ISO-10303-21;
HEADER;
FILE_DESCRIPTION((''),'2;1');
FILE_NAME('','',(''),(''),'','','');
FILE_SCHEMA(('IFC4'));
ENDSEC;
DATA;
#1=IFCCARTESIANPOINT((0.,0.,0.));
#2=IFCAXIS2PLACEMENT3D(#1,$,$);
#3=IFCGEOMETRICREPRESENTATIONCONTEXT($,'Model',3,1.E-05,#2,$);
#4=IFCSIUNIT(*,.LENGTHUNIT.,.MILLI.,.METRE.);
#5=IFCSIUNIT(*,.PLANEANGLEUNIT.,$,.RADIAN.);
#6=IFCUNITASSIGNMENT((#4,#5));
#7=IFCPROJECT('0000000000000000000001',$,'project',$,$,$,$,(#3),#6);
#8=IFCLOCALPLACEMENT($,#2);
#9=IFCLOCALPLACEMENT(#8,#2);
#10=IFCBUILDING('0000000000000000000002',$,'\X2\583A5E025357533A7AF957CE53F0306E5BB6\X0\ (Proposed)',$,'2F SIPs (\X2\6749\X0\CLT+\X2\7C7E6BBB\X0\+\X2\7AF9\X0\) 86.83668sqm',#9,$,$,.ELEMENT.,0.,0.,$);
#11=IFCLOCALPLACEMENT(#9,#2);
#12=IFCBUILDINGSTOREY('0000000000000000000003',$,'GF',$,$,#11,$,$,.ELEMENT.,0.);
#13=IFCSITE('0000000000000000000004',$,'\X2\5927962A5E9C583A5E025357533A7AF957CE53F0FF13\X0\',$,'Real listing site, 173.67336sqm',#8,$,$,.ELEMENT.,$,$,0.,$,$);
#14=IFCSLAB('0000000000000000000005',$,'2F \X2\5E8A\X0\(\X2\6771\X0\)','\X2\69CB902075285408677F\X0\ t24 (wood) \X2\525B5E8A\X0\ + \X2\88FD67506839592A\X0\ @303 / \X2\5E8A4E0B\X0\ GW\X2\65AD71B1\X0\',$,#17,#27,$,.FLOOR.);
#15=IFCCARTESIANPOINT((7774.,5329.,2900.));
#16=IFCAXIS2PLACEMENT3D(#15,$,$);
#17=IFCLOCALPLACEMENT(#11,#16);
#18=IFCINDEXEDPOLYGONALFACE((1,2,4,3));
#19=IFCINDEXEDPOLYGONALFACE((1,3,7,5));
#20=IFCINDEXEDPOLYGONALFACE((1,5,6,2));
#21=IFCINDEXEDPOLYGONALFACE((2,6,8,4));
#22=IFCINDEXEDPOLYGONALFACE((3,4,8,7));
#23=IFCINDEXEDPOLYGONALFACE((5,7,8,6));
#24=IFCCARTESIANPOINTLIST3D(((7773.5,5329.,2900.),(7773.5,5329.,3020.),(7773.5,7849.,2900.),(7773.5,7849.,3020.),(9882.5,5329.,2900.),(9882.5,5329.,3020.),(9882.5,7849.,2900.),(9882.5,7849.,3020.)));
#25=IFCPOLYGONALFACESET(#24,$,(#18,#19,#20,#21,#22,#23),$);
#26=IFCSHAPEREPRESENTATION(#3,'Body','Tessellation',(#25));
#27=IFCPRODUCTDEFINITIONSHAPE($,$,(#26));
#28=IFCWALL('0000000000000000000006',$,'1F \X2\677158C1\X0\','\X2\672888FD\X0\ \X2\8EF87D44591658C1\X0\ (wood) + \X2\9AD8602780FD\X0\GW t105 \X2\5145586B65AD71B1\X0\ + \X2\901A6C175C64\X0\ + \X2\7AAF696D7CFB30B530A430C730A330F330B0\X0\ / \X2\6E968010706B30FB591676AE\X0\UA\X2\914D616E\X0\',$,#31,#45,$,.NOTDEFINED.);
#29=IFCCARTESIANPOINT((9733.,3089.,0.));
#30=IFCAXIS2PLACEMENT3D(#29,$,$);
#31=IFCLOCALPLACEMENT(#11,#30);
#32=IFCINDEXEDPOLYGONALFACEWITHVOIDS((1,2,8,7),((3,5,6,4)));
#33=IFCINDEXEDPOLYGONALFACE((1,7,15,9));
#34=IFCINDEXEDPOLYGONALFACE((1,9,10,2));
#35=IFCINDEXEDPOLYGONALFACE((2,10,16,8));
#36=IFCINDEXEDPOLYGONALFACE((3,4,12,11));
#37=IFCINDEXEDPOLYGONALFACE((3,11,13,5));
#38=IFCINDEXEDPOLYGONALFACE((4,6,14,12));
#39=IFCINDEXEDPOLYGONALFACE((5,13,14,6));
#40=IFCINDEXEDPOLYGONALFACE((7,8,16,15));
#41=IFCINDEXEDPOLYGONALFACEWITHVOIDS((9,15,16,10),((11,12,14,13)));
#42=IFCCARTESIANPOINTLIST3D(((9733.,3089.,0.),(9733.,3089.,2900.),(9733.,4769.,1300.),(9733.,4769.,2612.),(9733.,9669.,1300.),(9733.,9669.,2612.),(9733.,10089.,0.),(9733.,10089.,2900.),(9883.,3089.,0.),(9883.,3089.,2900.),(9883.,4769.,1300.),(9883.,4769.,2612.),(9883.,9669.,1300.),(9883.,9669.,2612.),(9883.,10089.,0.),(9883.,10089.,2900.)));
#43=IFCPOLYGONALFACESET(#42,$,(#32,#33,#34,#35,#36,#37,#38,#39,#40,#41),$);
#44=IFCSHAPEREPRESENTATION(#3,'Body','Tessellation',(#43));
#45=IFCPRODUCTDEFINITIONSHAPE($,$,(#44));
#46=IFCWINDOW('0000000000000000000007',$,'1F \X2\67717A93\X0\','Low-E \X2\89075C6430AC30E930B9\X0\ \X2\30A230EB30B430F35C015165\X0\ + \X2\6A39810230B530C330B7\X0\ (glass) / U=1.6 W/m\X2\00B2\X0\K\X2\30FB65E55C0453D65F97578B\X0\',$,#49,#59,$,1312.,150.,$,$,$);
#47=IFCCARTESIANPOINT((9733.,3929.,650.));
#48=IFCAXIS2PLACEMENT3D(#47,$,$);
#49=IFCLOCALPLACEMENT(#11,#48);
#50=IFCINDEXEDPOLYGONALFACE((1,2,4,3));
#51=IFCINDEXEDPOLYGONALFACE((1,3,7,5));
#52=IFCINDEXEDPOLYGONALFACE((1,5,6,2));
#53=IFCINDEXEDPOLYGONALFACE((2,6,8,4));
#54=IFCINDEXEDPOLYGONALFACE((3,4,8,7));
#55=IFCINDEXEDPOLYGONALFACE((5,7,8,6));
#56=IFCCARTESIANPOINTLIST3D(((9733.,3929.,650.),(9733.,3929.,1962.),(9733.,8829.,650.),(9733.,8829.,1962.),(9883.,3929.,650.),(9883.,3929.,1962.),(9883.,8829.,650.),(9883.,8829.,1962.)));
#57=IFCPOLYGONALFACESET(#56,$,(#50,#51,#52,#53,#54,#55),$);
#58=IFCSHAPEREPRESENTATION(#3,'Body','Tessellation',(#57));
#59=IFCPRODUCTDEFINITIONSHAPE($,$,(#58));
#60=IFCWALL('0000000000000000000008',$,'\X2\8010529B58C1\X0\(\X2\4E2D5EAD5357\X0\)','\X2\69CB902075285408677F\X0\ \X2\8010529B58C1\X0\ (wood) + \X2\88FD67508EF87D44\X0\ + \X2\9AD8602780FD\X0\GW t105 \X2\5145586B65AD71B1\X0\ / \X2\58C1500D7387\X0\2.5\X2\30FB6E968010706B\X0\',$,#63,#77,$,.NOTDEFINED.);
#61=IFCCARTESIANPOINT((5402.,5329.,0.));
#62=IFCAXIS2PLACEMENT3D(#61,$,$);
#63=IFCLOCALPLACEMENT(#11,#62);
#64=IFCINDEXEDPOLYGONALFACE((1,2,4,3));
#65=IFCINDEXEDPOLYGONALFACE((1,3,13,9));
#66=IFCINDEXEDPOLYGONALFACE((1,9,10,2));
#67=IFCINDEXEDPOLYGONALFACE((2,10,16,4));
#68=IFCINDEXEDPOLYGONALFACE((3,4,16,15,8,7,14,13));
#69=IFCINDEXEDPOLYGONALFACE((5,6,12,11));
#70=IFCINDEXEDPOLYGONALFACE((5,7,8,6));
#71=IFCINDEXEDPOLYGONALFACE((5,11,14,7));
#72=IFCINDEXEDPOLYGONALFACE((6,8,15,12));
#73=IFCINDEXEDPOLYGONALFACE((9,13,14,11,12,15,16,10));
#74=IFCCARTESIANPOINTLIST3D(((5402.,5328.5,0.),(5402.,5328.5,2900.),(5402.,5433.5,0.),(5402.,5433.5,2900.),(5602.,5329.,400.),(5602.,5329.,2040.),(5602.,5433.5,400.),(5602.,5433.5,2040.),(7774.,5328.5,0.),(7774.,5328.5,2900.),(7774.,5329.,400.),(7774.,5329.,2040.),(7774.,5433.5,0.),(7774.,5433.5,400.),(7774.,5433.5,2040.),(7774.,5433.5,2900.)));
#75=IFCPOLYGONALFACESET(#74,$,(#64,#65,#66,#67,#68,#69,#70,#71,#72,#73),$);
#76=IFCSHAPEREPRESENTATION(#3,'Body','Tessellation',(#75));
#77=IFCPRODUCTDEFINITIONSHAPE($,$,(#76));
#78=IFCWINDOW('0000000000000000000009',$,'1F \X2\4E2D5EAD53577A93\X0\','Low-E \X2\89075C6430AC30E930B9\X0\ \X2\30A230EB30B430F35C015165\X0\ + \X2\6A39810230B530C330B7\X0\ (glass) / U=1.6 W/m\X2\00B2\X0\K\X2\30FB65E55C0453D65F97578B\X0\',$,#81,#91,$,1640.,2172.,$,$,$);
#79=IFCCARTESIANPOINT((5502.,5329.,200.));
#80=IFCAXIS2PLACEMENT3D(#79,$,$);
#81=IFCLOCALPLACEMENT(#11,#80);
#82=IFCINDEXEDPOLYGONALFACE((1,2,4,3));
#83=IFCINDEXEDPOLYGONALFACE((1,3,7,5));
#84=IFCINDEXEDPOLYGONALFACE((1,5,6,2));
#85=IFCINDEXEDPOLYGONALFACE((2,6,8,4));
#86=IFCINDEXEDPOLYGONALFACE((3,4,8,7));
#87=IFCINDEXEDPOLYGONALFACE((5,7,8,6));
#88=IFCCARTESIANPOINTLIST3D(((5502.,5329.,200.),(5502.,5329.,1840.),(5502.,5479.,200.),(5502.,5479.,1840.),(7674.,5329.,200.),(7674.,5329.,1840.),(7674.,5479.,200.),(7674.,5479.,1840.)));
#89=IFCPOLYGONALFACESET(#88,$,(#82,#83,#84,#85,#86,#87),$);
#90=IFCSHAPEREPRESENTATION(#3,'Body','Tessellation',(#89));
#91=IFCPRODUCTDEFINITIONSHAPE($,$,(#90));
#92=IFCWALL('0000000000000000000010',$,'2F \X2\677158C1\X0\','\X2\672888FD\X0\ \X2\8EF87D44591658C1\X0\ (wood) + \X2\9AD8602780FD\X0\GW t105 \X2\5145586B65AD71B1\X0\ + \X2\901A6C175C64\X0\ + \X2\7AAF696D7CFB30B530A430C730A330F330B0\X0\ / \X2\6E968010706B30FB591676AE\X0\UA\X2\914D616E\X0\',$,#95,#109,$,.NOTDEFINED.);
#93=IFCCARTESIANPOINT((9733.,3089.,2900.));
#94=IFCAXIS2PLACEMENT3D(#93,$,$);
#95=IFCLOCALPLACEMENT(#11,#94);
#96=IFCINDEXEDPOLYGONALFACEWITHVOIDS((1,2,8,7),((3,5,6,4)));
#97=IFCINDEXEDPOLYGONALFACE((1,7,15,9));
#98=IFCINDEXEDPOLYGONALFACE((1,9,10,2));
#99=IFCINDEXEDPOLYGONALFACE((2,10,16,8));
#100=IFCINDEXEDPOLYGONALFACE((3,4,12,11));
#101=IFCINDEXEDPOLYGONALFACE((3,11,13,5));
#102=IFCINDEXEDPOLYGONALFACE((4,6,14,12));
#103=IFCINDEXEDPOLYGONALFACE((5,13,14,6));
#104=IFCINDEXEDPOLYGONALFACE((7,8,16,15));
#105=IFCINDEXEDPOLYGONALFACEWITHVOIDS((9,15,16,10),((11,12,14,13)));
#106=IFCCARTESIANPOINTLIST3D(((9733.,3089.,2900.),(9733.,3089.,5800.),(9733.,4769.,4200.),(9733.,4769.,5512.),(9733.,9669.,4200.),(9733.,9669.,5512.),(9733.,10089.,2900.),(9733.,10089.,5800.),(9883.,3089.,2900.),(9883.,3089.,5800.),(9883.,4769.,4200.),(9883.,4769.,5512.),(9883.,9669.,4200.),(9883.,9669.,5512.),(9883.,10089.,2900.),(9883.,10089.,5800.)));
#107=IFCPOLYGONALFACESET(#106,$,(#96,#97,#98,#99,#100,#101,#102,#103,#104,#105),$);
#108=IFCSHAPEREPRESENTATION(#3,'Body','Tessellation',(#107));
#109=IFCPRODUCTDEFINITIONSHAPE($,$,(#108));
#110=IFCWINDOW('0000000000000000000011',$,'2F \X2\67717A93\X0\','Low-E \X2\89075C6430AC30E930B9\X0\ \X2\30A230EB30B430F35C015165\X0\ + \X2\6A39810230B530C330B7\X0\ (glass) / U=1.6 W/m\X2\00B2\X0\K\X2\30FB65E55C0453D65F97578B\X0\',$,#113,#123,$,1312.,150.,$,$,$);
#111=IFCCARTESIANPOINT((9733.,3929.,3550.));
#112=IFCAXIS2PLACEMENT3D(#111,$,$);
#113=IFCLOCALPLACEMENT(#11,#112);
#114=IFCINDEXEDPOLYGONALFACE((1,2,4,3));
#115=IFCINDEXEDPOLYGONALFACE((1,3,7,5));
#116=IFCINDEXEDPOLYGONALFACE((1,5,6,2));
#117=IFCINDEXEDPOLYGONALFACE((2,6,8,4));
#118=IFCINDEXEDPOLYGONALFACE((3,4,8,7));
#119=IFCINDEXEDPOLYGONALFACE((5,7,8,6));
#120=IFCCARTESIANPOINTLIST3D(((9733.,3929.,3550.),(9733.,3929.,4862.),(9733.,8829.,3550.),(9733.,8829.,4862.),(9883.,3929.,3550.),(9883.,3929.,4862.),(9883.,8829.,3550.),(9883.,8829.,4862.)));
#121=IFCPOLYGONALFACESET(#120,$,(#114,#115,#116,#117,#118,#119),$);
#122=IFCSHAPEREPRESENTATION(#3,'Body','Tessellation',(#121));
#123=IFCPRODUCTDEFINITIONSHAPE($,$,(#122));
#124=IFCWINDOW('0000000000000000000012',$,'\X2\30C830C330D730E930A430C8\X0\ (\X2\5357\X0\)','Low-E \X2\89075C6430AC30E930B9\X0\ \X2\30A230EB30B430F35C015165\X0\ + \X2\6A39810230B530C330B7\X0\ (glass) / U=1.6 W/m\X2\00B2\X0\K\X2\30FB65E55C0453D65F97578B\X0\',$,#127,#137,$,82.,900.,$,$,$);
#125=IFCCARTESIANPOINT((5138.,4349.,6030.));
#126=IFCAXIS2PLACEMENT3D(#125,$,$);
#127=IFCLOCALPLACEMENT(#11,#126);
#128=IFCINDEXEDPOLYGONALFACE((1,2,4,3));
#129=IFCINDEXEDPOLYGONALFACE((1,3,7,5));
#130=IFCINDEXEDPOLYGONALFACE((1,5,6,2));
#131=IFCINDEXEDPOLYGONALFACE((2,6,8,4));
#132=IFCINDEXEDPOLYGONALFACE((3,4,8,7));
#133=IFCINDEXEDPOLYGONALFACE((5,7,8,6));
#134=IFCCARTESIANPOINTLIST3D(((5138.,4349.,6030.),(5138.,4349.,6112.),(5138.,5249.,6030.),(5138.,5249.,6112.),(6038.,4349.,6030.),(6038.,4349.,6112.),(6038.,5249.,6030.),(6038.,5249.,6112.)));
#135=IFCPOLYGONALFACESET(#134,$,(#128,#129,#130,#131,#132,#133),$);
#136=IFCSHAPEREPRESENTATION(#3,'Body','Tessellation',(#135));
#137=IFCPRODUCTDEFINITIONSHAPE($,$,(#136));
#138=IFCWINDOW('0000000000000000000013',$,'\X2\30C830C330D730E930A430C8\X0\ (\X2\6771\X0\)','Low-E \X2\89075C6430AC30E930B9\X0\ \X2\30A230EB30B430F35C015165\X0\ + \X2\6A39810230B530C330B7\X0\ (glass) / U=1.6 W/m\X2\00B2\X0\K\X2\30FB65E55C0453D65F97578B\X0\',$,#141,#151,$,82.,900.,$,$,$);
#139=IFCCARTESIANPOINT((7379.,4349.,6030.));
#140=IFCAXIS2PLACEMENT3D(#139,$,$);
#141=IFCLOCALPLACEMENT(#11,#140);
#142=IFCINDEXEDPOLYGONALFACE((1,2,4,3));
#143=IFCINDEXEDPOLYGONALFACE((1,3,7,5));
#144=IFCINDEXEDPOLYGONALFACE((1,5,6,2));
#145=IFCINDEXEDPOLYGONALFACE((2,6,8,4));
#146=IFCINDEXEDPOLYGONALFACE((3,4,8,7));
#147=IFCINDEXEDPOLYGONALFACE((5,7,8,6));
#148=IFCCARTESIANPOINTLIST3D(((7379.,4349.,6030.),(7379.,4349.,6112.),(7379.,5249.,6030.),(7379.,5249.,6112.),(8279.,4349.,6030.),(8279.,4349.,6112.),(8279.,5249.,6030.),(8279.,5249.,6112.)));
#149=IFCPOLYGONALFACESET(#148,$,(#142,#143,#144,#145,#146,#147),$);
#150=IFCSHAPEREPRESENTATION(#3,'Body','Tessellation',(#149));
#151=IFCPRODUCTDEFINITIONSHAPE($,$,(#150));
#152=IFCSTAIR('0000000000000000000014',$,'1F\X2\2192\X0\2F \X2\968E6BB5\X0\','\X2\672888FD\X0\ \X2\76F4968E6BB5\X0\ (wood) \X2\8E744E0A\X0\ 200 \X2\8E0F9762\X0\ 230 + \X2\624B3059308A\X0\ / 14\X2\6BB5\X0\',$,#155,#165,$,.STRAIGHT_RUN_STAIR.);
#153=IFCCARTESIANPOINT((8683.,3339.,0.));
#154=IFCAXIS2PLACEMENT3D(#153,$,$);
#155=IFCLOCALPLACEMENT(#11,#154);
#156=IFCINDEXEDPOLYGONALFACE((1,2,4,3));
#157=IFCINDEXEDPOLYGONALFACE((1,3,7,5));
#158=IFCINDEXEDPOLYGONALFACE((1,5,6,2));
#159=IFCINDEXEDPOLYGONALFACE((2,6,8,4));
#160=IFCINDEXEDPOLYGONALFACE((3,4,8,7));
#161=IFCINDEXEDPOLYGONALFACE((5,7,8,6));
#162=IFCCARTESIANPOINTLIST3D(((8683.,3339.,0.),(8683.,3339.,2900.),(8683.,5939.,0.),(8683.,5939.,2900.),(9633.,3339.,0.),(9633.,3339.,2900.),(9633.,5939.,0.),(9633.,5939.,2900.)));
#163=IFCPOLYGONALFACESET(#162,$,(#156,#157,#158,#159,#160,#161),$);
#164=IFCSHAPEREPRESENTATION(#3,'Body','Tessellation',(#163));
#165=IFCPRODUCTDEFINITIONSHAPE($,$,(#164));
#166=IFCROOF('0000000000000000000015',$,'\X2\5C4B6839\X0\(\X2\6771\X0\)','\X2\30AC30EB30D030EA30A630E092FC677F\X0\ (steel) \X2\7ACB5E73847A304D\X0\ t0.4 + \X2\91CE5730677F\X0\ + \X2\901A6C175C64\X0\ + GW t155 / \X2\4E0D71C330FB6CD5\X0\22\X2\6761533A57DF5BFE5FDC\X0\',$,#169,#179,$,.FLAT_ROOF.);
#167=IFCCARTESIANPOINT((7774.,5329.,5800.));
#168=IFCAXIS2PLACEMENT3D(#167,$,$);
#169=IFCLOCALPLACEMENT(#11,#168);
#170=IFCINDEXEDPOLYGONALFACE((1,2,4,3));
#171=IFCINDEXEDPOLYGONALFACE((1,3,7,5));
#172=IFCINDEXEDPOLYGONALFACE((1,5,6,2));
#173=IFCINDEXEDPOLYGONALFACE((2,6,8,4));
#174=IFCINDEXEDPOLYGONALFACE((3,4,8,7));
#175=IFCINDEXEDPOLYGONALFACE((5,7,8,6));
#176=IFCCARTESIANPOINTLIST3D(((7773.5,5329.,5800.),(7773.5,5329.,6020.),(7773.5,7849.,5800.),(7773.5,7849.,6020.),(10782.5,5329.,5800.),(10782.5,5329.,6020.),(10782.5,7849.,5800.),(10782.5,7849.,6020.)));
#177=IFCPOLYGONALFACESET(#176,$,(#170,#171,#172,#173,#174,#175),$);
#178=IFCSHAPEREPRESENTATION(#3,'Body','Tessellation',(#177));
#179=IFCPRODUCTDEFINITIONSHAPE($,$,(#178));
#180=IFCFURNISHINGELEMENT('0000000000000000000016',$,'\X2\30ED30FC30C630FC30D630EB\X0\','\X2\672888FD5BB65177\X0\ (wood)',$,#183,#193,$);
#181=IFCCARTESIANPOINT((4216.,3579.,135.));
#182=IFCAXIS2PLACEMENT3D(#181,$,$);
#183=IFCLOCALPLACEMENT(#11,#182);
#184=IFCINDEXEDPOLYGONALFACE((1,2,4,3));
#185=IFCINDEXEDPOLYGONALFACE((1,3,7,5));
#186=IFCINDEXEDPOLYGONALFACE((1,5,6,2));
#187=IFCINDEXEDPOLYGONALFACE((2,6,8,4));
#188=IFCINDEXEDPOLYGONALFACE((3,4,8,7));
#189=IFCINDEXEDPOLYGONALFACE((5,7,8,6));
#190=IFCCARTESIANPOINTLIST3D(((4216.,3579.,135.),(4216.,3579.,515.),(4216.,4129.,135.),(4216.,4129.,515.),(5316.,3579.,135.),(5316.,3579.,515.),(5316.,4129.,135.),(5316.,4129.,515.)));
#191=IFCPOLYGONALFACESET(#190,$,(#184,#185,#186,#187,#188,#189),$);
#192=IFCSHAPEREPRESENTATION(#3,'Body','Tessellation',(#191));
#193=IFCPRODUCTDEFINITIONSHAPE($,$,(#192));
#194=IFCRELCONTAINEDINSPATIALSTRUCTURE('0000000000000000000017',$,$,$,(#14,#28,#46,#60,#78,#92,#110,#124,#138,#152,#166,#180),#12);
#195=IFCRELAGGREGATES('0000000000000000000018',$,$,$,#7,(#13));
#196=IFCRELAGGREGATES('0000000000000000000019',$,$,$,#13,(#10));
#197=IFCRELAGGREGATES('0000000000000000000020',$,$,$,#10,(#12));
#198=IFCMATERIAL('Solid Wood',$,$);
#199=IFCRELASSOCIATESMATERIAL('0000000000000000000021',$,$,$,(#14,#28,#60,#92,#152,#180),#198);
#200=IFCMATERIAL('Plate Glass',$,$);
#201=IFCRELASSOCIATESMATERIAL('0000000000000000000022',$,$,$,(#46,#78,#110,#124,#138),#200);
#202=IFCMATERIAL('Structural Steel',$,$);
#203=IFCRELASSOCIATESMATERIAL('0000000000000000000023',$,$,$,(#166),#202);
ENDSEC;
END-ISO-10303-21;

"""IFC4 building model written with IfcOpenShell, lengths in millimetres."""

from ifc_helpers import new_model, si_unit, frame, frame_2d, origin, place, context, project, spatial, rectangle, extrude, material, element, fill, save


model = new_model("IFC4")

# Units and contexts
model_context = context("Model", 3, precision=1e-05, world=origin())
ifc_project = project(units=[si_unit("LENGTHUNIT", "METRE", prefix="MILLI"), si_unit("PLANEANGLEUNIT", "RADIAN")], contexts=[model_context])

# Site, building, storey
site_placement = place(None, origin())
site = spatial("IfcSite", under=ifc_project, at=site_placement, Name="大阪府堺市南区竹城台３", ObjectType="Real listing site, 173.67336sqm", CompositionType="ELEMENT", RefElevation=0.0)
building_placement = place(site_placement, origin())
building = spatial("IfcBuilding", under=site, at=building_placement, Name="堺市南区竹城台の家 (Proposed)", ObjectType="2F SIPs (杉CLT+籾殻+竹) 86.83668sqm", CompositionType="ELEMENT", ElevationOfRefHeight=0.0, ElevationOfTerrain=0.0)
storey_placement = place(building_placement, origin())
storey = spatial("IfcBuildingStorey", under=building, at=storey_placement, Name="GF", CompositionType="ELEMENT", Elevation=0.0)

# Slab
ifc_material_1 = material(Name="Solid Wood")
slab_1_placement = place(storey_placement, frame((7774.0, 5329.0, 2900.0)))
element("IfcSlab", 1, at=slab_1_placement, inside=storey, material=ifc_material_1, Name="2F 床(東)", Description="構造用合板 t24 (wood) 剛床 + 製材根太 @303 / 床下 GW断熱", PredefinedType="FLOOR", context=model_context, shape_type="SweptSolid", body=[
    extrude(rectangle(XDim=2109.0, YDim=2520.0, at=frame_2d((1054.0, 1260.0))), frame((7774.0, 5329.0, 2900.0)), (0.0, 0.0, 1.0), 120.0),
])

# Walls, openings, windows
wall_1_placement = place(storey_placement, frame((9733.0, 3089.0, 0.0)))
wall_1 = element("IfcWall", 2, at=wall_1_placement, inside=storey, material=ifc_material_1, Name="1F 東壁", Description="木製 軸組外壁 (wood) + 高性能GW t105 充填断熱 + 通気層 + 窯業系サイディング / 準耐火・外皮UA配慮", PredefinedType="NOTDEFINED", context=model_context, shape_type="SweptSolid", body=[
    extrude(rectangle(XDim=150.0, YDim=7000.0, at=frame_2d((75.0, 3500.0))), frame((9733.0, 3089.0, 0.0)), (0.0, 0.0, 1.0), 2900.0),
])
opening_1_placement = place(storey_placement, frame((9733.0, 3929.0, 650.0)))
opening_1 = element("IfcOpeningElement", 3, at=opening_1_placement, cuts=wall_1, PredefinedType="NOTDEFINED", context=model_context, shape_type="SweptSolid", body=[
    extrude(rectangle(XDim=150.0, YDim=4900.0, at=frame_2d((75.0, 2450.0))), frame((9733.0, 3929.0, 650.0)), (0.0, 0.0, 1.0), 1312.0),
])
ifc_material_2 = material(Name="Plate Glass")
window_1_placement = place(storey_placement, frame((9733.0, 3929.0, 650.0)))
window_1 = element("IfcWindow", 4, at=window_1_placement, inside=storey, material=ifc_material_2, Name="1F 東窓", Description="Low-E 複層ガラス アルゴン封入 + 樹脂サッシ (glass) / U=1.6 W/m²K・日射取得型", OverallHeight=1312.0, OverallWidth=150.0, context=model_context, shape_type="SweptSolid", body=[
    extrude(rectangle(XDim=150.0, YDim=4900.0, at=frame_2d((75.0, 2450.0))), frame((9733.0, 3929.0, 650.0)), (0.0, 0.0, 1.0), 1312.0),
])
fill(opening_1, window_1)
wall_2_placement = place(storey_placement, frame((5402.0, 5329.0, 0.0)))
wall_2 = element("IfcWall", 5, at=wall_2_placement, inside=storey, material=ifc_material_1, Name="耐力壁(中庭南)", Description="構造用合板 耐力壁 (wood) + 製材軸組 + 高性能GW t105 充填断熱 / 壁倍率2.5・準耐火", PredefinedType="NOTDEFINED", context=model_context, shape_type="SweptSolid", body=[
    extrude(rectangle(XDim=2372.0, YDim=105.0, at=frame_2d((1186.0, 52.0))), frame((5402.0, 5329.0, 0.0)), (0.0, 0.0, 1.0), 2900.0),
])
opening_2_placement = place(storey_placement, frame((5502.0, 5329.0, 200.0)))
opening_2 = element("IfcOpeningElement", 6, at=opening_2_placement, cuts=wall_2, PredefinedType="NOTDEFINED", context=model_context, shape_type="SweptSolid", body=[
    extrude(rectangle(XDim=2172.0, YDim=150.0, at=frame_2d((1086.0, 75.0))), frame((5502.0, 5329.0, 200.0)), (0.0, 0.0, 1.0), 1640.0),
])
window_2_placement = place(storey_placement, frame((5502.0, 5329.0, 200.0)))
window_2 = element("IfcWindow", 7, at=window_2_placement, inside=storey, material=ifc_material_2, Name="1F 中庭南窓", Description="Low-E 複層ガラス アルゴン封入 + 樹脂サッシ (glass) / U=1.6 W/m²K・日射取得型", OverallHeight=1640.0, OverallWidth=2172.0, context=model_context, shape_type="SweptSolid", body=[
    extrude(rectangle(XDim=2172.0, YDim=150.0, at=frame_2d((1086.0, 75.0))), frame((5502.0, 5329.0, 200.0)), (0.0, 0.0, 1.0), 1640.0),
])
fill(opening_2, window_2)

# Wall, opening, window
wall_3_placement = place(storey_placement, frame((9733.0, 3089.0, 2900.0)))
wall_3 = element("IfcWall", 8, at=wall_3_placement, inside=storey, material=ifc_material_1, Name="2F 東壁", Description="木製 軸組外壁 (wood) + 高性能GW t105 充填断熱 + 通気層 + 窯業系サイディング / 準耐火・外皮UA配慮", PredefinedType="NOTDEFINED", context=model_context, shape_type="SweptSolid", body=[
    extrude(rectangle(XDim=150.0, YDim=7000.0, at=frame_2d((75.0, 3500.0))), frame((9733.0, 3089.0, 2900.0)), (0.0, 0.0, 1.0), 2900.0),
])
opening_3_placement = place(storey_placement, frame((9733.0, 3929.0, 3550.0)))
opening_3 = element("IfcOpeningElement", 9, at=opening_3_placement, cuts=wall_3, PredefinedType="NOTDEFINED", context=model_context, shape_type="SweptSolid", body=[
    extrude(rectangle(XDim=150.0, YDim=4900.0, at=frame_2d((75.0, 2450.0))), frame((9733.0, 3929.0, 3550.0)), (0.0, 0.0, 1.0), 1312.0),
])
window_3_placement = place(storey_placement, frame((9733.0, 3929.0, 3550.0)))
window_3 = element("IfcWindow", 10, at=window_3_placement, inside=storey, material=ifc_material_2, Name="2F 東窓", Description="Low-E 複層ガラス アルゴン封入 + 樹脂サッシ (glass) / U=1.6 W/m²K・日射取得型", OverallHeight=1312.0, OverallWidth=150.0, context=model_context, shape_type="SweptSolid", body=[
    extrude(rectangle(XDim=150.0, YDim=4900.0, at=frame_2d((75.0, 2450.0))), frame((9733.0, 3929.0, 3550.0)), (0.0, 0.0, 1.0), 1312.0),
])
fill(opening_3, window_3)

# Windows
window_4_placement = place(storey_placement, frame((5138.0, 4349.0, 6030.0)))
element("IfcWindow", 11, at=window_4_placement, inside=storey, material=ifc_material_2, Name="トップライト (南)", Description="Low-E 複層ガラス アルゴン封入 + 樹脂サッシ (glass) / U=1.6 W/m²K・日射取得型", OverallHeight=82.0, OverallWidth=900.0, context=model_context, shape_type="SweptSolid", body=[
    extrude(rectangle(XDim=900.0, YDim=900.0, at=frame_2d((450.0, 450.0))), frame((5138.0, 4349.0, 6030.0)), (0.0, 0.0, 1.0), 82.0),
])
window_5_placement = place(storey_placement, frame((7379.0, 4349.0, 6030.0)))
element("IfcWindow", 12, at=window_5_placement, inside=storey, material=ifc_material_2, Name="トップライト (東)", Description="Low-E 複層ガラス アルゴン封入 + 樹脂サッシ (glass) / U=1.6 W/m²K・日射取得型", OverallHeight=82.0, OverallWidth=900.0, context=model_context, shape_type="SweptSolid", body=[
    extrude(rectangle(XDim=900.0, YDim=900.0, at=frame_2d((450.0, 450.0))), frame((7379.0, 4349.0, 6030.0)), (0.0, 0.0, 1.0), 82.0),
])

# Stair
stair_placement = place(storey_placement, frame((8683.0, 3339.0, 0.0)))
element("IfcStair", 13, at=stair_placement, inside=storey, material=ifc_material_1, Name="1F→2F 階段", Description="木製 直階段 (wood) 蹴上 200 踏面 230 + 手すり / 14段", PredefinedType="STRAIGHT_RUN_STAIR", context=model_context, shape_type="SweptSolid", body=[
    extrude(rectangle(XDim=950.0, YDim=2600.0, at=frame_2d((475.0, 1300.0))), frame((8683.0, 3339.0, 0.0)), (0.0, 0.0, 1.0), 2900.0),
])

# Roof
ifc_material_3 = material(Name="Structural Steel")
roof_placement = place(storey_placement, frame((7774.0, 5329.0, 5800.0)))
element("IfcRoof", 14, at=roof_placement, inside=storey, material=ifc_material_3, Name="屋根(東)", Description="ガルバリウム鋼板 (steel) 立平葺き t0.4 + 野地板 + 通気層 + GW t155 / 不燃・法22条区域対応", PredefinedType="FLAT_ROOF", context=model_context, shape_type="SweptSolid", body=[
    extrude(rectangle(XDim=3009.0, YDim=2520.0, at=frame_2d((1504.0, 1260.0))), frame((7774.0, 5329.0, 5800.0)), (0.0, 0.0, 1.0), 220.0),
])

# Furnishing element
furnishing_1_placement = place(storey_placement, frame((4216.0, 3579.0, 135.0)))
element("IfcFurnishingElement", 15, at=furnishing_1_placement, inside=storey, material=ifc_material_1, Name="ローテーブル", Description="木製家具 (wood)", context=model_context, shape_type="SweptSolid", body=[
    extrude(rectangle(XDim=1100.0, YDim=550.0, at=frame_2d((550.0, 275.0))), frame((4216.0, 3579.0, 135.0)), (0.0, 0.0, 1.0), 380.0),
])

save(model, "model.ifc")
